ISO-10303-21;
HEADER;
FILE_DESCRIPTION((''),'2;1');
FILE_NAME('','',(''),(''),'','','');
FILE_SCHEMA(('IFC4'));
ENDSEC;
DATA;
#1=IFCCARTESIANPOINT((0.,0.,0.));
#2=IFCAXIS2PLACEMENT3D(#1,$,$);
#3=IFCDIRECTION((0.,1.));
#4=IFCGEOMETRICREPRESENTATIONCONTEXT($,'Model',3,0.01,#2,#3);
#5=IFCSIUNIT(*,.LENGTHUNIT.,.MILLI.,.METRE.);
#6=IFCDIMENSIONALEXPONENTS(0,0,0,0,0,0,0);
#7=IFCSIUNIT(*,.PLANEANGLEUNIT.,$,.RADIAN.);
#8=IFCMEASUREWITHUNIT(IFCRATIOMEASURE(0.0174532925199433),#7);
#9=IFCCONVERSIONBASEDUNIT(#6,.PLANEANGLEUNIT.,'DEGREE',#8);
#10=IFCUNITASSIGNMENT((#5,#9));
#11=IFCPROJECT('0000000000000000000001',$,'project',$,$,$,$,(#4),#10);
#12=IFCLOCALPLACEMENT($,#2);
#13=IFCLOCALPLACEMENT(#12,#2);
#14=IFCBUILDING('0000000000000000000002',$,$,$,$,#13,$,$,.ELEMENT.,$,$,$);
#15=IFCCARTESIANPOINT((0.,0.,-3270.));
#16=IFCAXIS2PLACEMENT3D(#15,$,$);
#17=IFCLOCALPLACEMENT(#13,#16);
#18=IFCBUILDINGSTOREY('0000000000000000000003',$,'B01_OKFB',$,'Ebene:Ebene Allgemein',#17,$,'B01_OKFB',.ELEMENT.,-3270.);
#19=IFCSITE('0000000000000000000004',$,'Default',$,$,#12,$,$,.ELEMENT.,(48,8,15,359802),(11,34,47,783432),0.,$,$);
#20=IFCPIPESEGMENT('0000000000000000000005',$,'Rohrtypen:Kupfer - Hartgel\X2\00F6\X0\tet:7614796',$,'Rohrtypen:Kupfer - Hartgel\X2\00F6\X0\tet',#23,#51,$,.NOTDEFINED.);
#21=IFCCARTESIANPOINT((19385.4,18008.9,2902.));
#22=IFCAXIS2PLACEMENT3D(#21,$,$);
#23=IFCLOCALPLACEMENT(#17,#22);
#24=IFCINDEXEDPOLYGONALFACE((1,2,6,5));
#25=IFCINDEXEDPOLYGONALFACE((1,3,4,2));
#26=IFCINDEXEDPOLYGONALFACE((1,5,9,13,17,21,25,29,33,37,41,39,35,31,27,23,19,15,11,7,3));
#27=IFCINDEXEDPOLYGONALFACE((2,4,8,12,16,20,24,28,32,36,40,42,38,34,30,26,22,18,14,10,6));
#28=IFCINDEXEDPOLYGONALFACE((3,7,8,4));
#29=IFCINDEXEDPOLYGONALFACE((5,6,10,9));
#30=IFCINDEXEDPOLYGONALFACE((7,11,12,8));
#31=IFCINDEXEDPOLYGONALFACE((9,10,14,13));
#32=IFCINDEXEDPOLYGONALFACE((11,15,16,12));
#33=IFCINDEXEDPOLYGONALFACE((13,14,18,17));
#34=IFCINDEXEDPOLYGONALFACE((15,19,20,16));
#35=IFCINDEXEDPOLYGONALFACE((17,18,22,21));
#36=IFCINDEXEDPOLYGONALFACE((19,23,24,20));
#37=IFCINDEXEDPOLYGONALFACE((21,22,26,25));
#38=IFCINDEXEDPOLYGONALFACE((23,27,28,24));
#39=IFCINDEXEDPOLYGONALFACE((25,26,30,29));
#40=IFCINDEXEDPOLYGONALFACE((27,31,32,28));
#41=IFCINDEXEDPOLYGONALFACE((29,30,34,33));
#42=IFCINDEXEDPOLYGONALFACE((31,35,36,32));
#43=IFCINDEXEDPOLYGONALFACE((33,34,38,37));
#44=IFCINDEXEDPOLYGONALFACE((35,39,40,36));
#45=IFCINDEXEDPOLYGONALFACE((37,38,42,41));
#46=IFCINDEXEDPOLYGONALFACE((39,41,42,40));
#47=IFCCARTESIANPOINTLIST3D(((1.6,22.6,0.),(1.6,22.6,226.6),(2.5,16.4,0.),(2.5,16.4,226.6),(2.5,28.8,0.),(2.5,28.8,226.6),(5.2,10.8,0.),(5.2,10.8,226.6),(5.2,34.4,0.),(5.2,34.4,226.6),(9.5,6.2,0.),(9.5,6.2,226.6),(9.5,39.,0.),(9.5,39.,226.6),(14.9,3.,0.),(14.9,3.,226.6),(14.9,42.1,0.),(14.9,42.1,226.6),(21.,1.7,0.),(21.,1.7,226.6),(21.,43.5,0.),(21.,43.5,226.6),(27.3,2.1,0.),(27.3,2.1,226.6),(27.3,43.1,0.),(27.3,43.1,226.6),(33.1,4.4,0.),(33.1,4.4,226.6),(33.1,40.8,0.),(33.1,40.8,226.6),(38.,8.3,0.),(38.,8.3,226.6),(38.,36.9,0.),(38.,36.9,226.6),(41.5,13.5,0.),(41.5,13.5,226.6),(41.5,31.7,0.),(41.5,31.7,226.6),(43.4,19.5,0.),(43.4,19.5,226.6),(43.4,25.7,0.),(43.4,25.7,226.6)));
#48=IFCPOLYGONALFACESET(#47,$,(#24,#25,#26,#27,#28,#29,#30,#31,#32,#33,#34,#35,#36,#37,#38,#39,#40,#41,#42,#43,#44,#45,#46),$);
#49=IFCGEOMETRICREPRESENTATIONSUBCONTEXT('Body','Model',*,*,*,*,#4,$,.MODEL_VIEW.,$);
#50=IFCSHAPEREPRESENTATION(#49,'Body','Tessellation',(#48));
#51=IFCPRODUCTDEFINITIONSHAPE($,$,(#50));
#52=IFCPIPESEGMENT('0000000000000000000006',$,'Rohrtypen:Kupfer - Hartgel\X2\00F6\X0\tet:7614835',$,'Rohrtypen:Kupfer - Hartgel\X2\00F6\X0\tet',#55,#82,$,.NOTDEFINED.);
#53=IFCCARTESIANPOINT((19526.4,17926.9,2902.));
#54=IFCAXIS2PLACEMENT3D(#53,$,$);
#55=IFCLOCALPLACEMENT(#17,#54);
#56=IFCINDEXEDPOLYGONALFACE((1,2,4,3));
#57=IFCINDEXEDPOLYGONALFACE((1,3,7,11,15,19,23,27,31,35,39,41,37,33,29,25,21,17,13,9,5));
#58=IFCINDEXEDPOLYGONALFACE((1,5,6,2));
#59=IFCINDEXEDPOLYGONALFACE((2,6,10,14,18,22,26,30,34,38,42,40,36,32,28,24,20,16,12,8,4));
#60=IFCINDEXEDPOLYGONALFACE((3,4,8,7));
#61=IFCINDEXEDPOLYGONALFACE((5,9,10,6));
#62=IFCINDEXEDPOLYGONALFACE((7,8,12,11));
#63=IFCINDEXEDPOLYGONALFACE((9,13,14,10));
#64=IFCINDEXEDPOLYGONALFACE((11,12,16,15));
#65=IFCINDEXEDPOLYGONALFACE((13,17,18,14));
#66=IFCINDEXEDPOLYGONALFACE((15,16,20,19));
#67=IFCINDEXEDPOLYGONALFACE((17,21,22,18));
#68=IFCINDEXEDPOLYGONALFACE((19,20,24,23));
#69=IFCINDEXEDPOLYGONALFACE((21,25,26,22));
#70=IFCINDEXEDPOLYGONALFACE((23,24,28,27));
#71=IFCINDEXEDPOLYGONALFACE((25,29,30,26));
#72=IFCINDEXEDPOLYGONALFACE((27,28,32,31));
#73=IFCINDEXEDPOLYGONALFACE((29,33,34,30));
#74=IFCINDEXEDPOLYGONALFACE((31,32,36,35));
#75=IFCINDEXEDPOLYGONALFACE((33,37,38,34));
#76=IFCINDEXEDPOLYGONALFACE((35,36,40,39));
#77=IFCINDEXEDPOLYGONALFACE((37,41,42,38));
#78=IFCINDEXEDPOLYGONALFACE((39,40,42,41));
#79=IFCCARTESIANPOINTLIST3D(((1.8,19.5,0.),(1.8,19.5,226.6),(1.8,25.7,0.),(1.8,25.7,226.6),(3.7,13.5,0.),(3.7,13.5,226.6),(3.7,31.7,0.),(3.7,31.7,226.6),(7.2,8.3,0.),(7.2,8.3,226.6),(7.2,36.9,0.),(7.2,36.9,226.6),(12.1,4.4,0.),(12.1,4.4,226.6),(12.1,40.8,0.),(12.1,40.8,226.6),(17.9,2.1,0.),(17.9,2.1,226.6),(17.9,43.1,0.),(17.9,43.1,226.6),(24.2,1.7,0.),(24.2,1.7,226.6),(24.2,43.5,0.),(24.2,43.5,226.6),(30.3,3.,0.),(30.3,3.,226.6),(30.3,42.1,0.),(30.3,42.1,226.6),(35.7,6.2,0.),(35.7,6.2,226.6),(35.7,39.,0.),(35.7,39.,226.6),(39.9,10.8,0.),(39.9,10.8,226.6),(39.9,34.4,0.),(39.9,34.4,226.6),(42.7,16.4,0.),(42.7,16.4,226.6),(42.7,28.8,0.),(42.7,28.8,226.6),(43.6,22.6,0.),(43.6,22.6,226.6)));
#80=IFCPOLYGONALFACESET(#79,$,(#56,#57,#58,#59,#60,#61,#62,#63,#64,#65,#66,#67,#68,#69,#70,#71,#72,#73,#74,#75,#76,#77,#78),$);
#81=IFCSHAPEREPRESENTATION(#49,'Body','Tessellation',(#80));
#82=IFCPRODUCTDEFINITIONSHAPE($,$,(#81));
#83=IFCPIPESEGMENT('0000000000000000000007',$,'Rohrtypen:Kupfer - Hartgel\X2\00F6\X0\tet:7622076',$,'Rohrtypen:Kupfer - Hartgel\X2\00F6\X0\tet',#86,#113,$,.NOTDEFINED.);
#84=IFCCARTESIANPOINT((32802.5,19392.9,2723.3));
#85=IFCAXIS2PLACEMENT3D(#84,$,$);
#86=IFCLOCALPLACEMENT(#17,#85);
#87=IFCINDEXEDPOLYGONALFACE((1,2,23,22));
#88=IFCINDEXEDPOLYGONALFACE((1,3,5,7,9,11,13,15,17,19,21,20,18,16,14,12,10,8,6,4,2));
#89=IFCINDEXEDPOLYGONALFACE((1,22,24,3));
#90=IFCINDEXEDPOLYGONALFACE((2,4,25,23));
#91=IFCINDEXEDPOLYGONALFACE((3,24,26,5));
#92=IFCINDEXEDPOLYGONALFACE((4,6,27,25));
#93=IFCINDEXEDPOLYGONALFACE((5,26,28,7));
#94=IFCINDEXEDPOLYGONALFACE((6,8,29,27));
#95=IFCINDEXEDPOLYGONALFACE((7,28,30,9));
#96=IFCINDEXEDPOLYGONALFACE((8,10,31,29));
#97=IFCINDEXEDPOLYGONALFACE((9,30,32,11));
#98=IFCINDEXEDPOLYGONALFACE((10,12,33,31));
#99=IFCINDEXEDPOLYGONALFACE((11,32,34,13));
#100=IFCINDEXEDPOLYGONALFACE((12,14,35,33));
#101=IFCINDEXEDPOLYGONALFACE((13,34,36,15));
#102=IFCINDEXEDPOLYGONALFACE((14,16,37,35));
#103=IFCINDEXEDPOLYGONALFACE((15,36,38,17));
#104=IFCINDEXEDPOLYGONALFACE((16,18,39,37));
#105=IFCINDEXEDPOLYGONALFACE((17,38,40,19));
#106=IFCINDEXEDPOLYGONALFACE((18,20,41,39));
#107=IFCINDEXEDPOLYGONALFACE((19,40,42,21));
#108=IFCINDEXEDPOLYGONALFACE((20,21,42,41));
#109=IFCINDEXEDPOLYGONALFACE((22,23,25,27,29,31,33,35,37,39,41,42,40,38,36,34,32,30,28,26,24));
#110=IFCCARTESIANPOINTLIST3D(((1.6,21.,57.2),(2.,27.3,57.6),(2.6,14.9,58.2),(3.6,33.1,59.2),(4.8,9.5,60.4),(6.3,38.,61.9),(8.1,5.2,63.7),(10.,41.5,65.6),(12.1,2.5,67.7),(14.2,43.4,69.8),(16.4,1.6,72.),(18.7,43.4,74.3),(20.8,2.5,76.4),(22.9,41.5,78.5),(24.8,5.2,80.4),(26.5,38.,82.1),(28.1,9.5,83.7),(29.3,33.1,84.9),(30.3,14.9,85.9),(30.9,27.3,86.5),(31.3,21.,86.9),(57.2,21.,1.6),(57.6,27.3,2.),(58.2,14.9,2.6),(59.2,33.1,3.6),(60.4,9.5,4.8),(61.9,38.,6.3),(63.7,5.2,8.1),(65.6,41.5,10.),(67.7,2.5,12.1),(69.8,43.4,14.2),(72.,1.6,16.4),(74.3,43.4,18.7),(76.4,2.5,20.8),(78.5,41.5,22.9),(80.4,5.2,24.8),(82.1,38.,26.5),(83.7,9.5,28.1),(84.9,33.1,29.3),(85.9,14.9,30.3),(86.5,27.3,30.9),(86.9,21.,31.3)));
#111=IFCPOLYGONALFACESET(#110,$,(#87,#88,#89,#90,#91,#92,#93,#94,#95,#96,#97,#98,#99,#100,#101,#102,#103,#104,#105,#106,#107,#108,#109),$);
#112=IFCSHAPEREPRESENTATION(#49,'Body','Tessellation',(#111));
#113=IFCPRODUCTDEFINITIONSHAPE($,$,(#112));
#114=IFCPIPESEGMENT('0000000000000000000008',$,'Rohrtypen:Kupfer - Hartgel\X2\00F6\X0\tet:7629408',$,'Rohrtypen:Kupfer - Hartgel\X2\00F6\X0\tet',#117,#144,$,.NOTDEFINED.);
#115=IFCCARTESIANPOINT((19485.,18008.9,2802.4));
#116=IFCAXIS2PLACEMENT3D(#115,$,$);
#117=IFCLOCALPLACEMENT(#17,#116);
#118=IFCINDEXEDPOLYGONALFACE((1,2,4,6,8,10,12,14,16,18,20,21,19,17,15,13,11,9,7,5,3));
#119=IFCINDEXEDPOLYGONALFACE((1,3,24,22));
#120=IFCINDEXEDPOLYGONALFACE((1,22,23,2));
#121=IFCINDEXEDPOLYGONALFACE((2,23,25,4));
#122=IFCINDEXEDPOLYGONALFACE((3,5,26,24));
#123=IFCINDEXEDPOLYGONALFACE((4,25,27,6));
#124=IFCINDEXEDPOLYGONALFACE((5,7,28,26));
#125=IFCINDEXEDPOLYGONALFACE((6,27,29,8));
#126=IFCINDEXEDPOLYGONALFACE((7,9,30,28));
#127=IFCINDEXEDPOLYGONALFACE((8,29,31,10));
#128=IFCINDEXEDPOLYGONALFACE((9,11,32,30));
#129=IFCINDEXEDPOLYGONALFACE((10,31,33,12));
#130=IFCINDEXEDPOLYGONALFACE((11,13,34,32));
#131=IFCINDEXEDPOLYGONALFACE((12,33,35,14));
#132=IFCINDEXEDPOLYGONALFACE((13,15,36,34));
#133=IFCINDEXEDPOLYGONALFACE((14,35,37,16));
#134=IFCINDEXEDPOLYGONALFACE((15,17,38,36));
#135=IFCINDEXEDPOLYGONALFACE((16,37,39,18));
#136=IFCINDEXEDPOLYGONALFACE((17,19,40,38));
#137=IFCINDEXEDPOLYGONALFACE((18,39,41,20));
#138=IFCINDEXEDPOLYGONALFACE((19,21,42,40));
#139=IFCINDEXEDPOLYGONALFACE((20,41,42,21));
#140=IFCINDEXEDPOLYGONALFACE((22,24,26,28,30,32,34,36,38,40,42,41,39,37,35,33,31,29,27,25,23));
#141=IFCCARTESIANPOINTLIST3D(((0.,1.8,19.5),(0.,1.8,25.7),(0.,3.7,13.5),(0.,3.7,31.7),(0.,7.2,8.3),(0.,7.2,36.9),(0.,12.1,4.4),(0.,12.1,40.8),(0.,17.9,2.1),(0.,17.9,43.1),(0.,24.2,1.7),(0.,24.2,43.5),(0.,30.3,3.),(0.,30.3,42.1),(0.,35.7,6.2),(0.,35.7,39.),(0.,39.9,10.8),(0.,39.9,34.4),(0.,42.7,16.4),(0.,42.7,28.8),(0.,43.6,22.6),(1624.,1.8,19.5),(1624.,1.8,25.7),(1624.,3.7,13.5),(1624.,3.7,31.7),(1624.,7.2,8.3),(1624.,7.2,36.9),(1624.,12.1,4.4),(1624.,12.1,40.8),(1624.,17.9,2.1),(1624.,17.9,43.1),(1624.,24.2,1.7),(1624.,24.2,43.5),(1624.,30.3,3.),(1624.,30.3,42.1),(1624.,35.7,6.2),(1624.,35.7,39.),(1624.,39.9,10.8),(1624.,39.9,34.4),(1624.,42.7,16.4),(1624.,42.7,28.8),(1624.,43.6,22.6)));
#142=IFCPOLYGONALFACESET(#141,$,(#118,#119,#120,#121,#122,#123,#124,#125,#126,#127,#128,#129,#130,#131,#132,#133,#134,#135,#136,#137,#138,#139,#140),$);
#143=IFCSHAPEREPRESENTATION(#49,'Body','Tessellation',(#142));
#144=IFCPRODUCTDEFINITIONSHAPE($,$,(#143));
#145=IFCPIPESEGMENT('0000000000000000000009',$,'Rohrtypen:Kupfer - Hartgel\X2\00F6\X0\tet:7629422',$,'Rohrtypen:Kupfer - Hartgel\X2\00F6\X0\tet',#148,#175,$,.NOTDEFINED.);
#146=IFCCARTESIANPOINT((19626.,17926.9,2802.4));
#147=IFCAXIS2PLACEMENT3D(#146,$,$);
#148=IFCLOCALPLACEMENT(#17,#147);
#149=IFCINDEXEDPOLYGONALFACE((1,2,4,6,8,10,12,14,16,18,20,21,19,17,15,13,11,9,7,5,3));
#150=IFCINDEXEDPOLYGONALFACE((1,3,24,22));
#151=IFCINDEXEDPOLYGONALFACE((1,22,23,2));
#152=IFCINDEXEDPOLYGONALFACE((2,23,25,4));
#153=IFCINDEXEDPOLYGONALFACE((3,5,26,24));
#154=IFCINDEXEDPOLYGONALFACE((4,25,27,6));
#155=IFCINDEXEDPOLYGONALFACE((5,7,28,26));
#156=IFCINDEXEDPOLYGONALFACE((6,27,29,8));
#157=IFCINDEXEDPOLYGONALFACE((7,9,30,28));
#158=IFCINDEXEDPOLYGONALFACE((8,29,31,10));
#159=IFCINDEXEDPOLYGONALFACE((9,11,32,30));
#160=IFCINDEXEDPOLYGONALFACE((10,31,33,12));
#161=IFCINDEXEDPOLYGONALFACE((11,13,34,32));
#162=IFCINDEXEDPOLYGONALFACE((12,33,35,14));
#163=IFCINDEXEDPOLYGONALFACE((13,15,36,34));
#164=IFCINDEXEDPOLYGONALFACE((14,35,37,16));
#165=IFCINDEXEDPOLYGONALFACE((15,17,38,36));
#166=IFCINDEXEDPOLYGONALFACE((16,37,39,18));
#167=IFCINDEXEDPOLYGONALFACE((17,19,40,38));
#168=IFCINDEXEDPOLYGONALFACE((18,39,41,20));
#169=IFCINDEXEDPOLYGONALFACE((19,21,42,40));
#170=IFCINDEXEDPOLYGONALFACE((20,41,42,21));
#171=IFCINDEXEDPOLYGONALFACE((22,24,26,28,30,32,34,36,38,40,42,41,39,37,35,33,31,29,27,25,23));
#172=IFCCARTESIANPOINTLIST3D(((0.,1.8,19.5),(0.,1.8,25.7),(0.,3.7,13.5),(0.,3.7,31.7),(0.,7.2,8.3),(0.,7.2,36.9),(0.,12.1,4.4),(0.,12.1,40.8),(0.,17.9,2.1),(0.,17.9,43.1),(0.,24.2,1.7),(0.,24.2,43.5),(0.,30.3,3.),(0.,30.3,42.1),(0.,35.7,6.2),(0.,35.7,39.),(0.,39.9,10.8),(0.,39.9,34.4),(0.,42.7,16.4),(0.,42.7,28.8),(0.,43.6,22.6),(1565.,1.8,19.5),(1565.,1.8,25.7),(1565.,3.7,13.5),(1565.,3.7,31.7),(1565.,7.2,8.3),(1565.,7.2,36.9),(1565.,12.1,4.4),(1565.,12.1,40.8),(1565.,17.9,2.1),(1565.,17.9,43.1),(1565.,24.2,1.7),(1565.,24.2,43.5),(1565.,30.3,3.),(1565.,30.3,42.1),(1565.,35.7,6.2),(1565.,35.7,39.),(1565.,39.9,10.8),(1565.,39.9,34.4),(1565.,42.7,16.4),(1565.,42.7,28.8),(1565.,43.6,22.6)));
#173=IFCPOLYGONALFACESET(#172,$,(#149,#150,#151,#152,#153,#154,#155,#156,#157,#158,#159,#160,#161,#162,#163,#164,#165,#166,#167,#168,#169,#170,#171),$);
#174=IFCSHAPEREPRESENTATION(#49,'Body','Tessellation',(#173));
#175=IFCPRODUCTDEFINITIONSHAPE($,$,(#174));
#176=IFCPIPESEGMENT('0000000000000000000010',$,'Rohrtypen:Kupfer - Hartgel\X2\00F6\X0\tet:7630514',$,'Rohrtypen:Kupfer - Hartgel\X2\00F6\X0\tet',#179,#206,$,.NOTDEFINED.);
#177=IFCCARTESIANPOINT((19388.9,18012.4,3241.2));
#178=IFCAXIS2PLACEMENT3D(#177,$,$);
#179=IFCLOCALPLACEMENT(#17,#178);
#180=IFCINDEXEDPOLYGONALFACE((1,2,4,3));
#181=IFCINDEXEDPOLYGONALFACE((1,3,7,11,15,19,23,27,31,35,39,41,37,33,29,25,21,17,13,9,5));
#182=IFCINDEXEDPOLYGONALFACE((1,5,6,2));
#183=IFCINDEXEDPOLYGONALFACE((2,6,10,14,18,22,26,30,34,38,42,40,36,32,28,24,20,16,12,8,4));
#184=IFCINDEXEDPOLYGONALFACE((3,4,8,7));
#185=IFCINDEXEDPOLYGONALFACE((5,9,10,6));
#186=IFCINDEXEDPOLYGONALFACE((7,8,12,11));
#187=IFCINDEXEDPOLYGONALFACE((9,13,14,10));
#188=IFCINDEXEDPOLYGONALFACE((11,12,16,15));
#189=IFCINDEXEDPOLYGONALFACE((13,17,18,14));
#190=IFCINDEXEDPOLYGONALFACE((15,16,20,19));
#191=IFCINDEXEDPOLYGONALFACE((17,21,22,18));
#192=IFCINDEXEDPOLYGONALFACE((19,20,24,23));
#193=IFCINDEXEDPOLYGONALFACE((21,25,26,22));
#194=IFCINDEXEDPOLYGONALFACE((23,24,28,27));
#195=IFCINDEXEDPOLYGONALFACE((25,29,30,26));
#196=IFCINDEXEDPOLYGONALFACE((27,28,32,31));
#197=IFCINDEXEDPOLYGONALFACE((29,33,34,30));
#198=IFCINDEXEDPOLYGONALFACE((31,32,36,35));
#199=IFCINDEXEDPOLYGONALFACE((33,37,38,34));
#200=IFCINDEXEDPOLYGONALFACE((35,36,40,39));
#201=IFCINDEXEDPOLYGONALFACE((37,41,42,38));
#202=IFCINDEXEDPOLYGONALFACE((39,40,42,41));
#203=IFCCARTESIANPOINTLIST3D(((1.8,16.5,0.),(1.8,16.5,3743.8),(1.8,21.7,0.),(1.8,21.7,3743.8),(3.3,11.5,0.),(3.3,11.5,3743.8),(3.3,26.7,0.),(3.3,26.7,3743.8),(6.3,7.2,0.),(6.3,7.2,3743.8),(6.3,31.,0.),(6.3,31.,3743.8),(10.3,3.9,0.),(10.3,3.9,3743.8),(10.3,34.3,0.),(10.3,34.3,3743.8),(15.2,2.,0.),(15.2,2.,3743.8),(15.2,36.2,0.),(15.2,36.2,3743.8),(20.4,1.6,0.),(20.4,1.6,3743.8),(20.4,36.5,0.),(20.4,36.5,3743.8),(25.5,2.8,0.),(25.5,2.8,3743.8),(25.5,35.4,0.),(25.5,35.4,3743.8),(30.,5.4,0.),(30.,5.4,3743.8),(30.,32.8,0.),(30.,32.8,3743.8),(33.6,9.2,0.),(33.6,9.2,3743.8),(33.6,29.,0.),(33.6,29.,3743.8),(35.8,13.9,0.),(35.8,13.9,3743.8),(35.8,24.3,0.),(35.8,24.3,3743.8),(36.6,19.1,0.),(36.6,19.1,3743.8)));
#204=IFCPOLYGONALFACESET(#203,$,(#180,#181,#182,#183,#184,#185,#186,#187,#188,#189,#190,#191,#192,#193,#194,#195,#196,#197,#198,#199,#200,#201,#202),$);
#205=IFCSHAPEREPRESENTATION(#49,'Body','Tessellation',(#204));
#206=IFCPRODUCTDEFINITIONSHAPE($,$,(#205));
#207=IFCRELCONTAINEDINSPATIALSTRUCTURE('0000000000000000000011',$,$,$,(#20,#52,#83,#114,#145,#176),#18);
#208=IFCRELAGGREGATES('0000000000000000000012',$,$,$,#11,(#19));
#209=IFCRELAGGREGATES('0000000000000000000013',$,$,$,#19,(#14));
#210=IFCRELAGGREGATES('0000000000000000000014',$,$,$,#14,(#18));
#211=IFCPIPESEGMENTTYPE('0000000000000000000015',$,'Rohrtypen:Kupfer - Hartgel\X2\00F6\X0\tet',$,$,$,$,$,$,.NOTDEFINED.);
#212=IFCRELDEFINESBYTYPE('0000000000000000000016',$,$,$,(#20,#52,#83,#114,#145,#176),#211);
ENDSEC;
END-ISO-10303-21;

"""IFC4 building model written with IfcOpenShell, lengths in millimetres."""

from ifc_helpers import new_model, entity, si_unit, converted_unit, direction, frame, frame_2d, origin, origin_2d_with_axis, place, context, subcontext, project, spatial, circle, extrude, type_object, element, save


model = new_model("IFC4")

# Units and contexts
model_context = context("Model", 3, precision=0.01, world=origin(), true_north=direction((0.0, 1.0)))
body_context = subcontext(model_context, "Body", "Model", "MODEL_VIEW")
ifc_project = project(units=[si_unit("LENGTHUNIT", "METRE", prefix="MILLI"), converted_unit("PLANEANGLEUNIT", "DEGREE", entity("IfcRatioMeasure", 0.0174532925199433), si_unit("PLANEANGLEUNIT", "RADIAN"), dimensions=[0, 0, 0, 0, 0, 0, 0])], contexts=[model_context])

# Site, building, storey
site_placement = place(None, origin())
site = spatial("IfcSite", under=ifc_project, at=site_placement, Name="Default", CompositionType="ELEMENT", RefLatitude=(48, 8, 15, 359802), RefLongitude=(11, 34, 47, 783432), RefElevation=0.0)
building_placement = place(site_placement, origin())
building = spatial("IfcBuilding", under=site, at=building_placement, CompositionType="ELEMENT")
storey_placement = place(building_placement, frame((0.0, 0.0, -3270.0)))
storey = spatial("IfcBuildingStorey", under=building, at=storey_placement, Name="B01_OKFB", ObjectType="Ebene:Ebene Allgemein", LongName="B01_OKFB", CompositionType="ELEMENT", Elevation=-3270.0)

# Pipe segments
pipe_segment_type = type_object("IfcPipeSegmentType", Name="Rohrtypen:Kupfer - Hartgelötet", PredefinedType="NOTDEFINED")
pipe_segment_1_placement = place(storey_placement, frame((19385.4, 18008.9, 2902.0)))
element("IfcPipeSegment", 1, at=pipe_segment_1_placement, inside=storey, type_object=pipe_segment_type, Name="Rohrtypen:Kupfer - Hartgelötet:7614796", ObjectType="Rohrtypen:Kupfer - Hartgelötet", PredefinedType="NOTDEFINED", context=body_context, shape_type="SweptSolid", body=[
    extrude(circle(Radius=21.0, at=origin_2d_with_axis()), frame((22.6, 22.6, 0.0), z_axis=(0.0, 0.0, 1.0), x_axis=(-1.0, 0.0, 0.0)), (0.0, 0.0, 1.0), 226.6),
])
pipe_segment_2_placement = place(storey_placement, frame((19526.4, 17926.9, 2902.0)))
element("IfcPipeSegment", 2, at=pipe_segment_2_placement, inside=storey, type_object=pipe_segment_type, Name="Rohrtypen:Kupfer - Hartgelötet:7614835", ObjectType="Rohrtypen:Kupfer - Hartgelötet", PredefinedType="NOTDEFINED", context=body_context, shape_type="SweptSolid", body=[
    extrude(circle(Radius=21.0, at=origin_2d_with_axis()), frame((22.6, 22.6, 0.0)), (0.0, 0.0, 1.0), 226.6),
])
pipe_segment_3_placement = place(storey_placement, frame((32802.5, 19392.9, 2723.3)))
element("IfcPipeSegment", 3, at=pipe_segment_3_placement, inside=storey, type_object=pipe_segment_type, Name="Rohrtypen:Kupfer - Hartgelötet:7622076", ObjectType="Rohrtypen:Kupfer - Hartgelötet", PredefinedType="NOTDEFINED", context=body_context, shape_type="SweptSolid", body=[
    extrude(circle(Radius=21.0, at=origin_2d_with_axis()), frame((16.4, 22.6, 72.0), z_axis=(0.707107, 0.0, -0.707107), x_axis=(0.0, -1.0, 0.0)), (0.0, 0.0, 1.0), 78.6),
])
pipe_segment_4_placement = place(storey_placement, frame((19485.0, 18008.9, 2802.4)))
element("IfcPipeSegment", 4, at=pipe_segment_4_placement, inside=storey, type_object=pipe_segment_type, Name="Rohrtypen:Kupfer - Hartgelötet:7629408", ObjectType="Rohrtypen:Kupfer - Hartgelötet", PredefinedType="NOTDEFINED", context=body_context, shape_type="SweptSolid", body=[
    extrude(circle(Radius=21.0, at=frame_2d((0.0, 0.0), x_axis=(1.0, 0.0))), frame((0.0, 22.6, 22.6), z_axis=(1.0, 0.0, 0.0), x_axis=(0.0, 1.0, 0.0)), (0.0, 0.0, 1.0), 1624.0),
])
pipe_segment_5_placement = place(storey_placement, frame((19626.0, 17926.9, 2802.4)))
element("IfcPipeSegment", 5, at=pipe_segment_5_placement, inside=storey, type_object=pipe_segment_type, Name="Rohrtypen:Kupfer - Hartgelötet:7629422", ObjectType="Rohrtypen:Kupfer - Hartgelötet", PredefinedType="NOTDEFINED", context=body_context, shape_type="SweptSolid", body=[
    extrude(circle(Radius=21.0, at=frame_2d((0.0, 0.0), x_axis=(1.0, 0.0))), frame((0.0, 22.6, 22.6), z_axis=(1.0, 0.0, 0.0), x_axis=(0.0, 1.0, 0.0)), (0.0, 0.0, 1.0), 1565.0),
])
pipe_segment_6_placement = place(storey_placement, frame((19388.9, 18012.4, 3241.2)))
element("IfcPipeSegment", 6, at=pipe_segment_6_placement, inside=storey, type_object=pipe_segment_type, Name="Rohrtypen:Kupfer - Hartgelötet:7630514", ObjectType="Rohrtypen:Kupfer - Hartgelötet", PredefinedType="NOTDEFINED", context=body_context, shape_type="SweptSolid", body=[
    extrude(circle(Radius=17.5, at=origin_2d_with_axis()), frame((19.1, 19.1, 0.0)), (0.0, 0.0, 1.0), 3743.8),
])

save(model, "model.ifc")
